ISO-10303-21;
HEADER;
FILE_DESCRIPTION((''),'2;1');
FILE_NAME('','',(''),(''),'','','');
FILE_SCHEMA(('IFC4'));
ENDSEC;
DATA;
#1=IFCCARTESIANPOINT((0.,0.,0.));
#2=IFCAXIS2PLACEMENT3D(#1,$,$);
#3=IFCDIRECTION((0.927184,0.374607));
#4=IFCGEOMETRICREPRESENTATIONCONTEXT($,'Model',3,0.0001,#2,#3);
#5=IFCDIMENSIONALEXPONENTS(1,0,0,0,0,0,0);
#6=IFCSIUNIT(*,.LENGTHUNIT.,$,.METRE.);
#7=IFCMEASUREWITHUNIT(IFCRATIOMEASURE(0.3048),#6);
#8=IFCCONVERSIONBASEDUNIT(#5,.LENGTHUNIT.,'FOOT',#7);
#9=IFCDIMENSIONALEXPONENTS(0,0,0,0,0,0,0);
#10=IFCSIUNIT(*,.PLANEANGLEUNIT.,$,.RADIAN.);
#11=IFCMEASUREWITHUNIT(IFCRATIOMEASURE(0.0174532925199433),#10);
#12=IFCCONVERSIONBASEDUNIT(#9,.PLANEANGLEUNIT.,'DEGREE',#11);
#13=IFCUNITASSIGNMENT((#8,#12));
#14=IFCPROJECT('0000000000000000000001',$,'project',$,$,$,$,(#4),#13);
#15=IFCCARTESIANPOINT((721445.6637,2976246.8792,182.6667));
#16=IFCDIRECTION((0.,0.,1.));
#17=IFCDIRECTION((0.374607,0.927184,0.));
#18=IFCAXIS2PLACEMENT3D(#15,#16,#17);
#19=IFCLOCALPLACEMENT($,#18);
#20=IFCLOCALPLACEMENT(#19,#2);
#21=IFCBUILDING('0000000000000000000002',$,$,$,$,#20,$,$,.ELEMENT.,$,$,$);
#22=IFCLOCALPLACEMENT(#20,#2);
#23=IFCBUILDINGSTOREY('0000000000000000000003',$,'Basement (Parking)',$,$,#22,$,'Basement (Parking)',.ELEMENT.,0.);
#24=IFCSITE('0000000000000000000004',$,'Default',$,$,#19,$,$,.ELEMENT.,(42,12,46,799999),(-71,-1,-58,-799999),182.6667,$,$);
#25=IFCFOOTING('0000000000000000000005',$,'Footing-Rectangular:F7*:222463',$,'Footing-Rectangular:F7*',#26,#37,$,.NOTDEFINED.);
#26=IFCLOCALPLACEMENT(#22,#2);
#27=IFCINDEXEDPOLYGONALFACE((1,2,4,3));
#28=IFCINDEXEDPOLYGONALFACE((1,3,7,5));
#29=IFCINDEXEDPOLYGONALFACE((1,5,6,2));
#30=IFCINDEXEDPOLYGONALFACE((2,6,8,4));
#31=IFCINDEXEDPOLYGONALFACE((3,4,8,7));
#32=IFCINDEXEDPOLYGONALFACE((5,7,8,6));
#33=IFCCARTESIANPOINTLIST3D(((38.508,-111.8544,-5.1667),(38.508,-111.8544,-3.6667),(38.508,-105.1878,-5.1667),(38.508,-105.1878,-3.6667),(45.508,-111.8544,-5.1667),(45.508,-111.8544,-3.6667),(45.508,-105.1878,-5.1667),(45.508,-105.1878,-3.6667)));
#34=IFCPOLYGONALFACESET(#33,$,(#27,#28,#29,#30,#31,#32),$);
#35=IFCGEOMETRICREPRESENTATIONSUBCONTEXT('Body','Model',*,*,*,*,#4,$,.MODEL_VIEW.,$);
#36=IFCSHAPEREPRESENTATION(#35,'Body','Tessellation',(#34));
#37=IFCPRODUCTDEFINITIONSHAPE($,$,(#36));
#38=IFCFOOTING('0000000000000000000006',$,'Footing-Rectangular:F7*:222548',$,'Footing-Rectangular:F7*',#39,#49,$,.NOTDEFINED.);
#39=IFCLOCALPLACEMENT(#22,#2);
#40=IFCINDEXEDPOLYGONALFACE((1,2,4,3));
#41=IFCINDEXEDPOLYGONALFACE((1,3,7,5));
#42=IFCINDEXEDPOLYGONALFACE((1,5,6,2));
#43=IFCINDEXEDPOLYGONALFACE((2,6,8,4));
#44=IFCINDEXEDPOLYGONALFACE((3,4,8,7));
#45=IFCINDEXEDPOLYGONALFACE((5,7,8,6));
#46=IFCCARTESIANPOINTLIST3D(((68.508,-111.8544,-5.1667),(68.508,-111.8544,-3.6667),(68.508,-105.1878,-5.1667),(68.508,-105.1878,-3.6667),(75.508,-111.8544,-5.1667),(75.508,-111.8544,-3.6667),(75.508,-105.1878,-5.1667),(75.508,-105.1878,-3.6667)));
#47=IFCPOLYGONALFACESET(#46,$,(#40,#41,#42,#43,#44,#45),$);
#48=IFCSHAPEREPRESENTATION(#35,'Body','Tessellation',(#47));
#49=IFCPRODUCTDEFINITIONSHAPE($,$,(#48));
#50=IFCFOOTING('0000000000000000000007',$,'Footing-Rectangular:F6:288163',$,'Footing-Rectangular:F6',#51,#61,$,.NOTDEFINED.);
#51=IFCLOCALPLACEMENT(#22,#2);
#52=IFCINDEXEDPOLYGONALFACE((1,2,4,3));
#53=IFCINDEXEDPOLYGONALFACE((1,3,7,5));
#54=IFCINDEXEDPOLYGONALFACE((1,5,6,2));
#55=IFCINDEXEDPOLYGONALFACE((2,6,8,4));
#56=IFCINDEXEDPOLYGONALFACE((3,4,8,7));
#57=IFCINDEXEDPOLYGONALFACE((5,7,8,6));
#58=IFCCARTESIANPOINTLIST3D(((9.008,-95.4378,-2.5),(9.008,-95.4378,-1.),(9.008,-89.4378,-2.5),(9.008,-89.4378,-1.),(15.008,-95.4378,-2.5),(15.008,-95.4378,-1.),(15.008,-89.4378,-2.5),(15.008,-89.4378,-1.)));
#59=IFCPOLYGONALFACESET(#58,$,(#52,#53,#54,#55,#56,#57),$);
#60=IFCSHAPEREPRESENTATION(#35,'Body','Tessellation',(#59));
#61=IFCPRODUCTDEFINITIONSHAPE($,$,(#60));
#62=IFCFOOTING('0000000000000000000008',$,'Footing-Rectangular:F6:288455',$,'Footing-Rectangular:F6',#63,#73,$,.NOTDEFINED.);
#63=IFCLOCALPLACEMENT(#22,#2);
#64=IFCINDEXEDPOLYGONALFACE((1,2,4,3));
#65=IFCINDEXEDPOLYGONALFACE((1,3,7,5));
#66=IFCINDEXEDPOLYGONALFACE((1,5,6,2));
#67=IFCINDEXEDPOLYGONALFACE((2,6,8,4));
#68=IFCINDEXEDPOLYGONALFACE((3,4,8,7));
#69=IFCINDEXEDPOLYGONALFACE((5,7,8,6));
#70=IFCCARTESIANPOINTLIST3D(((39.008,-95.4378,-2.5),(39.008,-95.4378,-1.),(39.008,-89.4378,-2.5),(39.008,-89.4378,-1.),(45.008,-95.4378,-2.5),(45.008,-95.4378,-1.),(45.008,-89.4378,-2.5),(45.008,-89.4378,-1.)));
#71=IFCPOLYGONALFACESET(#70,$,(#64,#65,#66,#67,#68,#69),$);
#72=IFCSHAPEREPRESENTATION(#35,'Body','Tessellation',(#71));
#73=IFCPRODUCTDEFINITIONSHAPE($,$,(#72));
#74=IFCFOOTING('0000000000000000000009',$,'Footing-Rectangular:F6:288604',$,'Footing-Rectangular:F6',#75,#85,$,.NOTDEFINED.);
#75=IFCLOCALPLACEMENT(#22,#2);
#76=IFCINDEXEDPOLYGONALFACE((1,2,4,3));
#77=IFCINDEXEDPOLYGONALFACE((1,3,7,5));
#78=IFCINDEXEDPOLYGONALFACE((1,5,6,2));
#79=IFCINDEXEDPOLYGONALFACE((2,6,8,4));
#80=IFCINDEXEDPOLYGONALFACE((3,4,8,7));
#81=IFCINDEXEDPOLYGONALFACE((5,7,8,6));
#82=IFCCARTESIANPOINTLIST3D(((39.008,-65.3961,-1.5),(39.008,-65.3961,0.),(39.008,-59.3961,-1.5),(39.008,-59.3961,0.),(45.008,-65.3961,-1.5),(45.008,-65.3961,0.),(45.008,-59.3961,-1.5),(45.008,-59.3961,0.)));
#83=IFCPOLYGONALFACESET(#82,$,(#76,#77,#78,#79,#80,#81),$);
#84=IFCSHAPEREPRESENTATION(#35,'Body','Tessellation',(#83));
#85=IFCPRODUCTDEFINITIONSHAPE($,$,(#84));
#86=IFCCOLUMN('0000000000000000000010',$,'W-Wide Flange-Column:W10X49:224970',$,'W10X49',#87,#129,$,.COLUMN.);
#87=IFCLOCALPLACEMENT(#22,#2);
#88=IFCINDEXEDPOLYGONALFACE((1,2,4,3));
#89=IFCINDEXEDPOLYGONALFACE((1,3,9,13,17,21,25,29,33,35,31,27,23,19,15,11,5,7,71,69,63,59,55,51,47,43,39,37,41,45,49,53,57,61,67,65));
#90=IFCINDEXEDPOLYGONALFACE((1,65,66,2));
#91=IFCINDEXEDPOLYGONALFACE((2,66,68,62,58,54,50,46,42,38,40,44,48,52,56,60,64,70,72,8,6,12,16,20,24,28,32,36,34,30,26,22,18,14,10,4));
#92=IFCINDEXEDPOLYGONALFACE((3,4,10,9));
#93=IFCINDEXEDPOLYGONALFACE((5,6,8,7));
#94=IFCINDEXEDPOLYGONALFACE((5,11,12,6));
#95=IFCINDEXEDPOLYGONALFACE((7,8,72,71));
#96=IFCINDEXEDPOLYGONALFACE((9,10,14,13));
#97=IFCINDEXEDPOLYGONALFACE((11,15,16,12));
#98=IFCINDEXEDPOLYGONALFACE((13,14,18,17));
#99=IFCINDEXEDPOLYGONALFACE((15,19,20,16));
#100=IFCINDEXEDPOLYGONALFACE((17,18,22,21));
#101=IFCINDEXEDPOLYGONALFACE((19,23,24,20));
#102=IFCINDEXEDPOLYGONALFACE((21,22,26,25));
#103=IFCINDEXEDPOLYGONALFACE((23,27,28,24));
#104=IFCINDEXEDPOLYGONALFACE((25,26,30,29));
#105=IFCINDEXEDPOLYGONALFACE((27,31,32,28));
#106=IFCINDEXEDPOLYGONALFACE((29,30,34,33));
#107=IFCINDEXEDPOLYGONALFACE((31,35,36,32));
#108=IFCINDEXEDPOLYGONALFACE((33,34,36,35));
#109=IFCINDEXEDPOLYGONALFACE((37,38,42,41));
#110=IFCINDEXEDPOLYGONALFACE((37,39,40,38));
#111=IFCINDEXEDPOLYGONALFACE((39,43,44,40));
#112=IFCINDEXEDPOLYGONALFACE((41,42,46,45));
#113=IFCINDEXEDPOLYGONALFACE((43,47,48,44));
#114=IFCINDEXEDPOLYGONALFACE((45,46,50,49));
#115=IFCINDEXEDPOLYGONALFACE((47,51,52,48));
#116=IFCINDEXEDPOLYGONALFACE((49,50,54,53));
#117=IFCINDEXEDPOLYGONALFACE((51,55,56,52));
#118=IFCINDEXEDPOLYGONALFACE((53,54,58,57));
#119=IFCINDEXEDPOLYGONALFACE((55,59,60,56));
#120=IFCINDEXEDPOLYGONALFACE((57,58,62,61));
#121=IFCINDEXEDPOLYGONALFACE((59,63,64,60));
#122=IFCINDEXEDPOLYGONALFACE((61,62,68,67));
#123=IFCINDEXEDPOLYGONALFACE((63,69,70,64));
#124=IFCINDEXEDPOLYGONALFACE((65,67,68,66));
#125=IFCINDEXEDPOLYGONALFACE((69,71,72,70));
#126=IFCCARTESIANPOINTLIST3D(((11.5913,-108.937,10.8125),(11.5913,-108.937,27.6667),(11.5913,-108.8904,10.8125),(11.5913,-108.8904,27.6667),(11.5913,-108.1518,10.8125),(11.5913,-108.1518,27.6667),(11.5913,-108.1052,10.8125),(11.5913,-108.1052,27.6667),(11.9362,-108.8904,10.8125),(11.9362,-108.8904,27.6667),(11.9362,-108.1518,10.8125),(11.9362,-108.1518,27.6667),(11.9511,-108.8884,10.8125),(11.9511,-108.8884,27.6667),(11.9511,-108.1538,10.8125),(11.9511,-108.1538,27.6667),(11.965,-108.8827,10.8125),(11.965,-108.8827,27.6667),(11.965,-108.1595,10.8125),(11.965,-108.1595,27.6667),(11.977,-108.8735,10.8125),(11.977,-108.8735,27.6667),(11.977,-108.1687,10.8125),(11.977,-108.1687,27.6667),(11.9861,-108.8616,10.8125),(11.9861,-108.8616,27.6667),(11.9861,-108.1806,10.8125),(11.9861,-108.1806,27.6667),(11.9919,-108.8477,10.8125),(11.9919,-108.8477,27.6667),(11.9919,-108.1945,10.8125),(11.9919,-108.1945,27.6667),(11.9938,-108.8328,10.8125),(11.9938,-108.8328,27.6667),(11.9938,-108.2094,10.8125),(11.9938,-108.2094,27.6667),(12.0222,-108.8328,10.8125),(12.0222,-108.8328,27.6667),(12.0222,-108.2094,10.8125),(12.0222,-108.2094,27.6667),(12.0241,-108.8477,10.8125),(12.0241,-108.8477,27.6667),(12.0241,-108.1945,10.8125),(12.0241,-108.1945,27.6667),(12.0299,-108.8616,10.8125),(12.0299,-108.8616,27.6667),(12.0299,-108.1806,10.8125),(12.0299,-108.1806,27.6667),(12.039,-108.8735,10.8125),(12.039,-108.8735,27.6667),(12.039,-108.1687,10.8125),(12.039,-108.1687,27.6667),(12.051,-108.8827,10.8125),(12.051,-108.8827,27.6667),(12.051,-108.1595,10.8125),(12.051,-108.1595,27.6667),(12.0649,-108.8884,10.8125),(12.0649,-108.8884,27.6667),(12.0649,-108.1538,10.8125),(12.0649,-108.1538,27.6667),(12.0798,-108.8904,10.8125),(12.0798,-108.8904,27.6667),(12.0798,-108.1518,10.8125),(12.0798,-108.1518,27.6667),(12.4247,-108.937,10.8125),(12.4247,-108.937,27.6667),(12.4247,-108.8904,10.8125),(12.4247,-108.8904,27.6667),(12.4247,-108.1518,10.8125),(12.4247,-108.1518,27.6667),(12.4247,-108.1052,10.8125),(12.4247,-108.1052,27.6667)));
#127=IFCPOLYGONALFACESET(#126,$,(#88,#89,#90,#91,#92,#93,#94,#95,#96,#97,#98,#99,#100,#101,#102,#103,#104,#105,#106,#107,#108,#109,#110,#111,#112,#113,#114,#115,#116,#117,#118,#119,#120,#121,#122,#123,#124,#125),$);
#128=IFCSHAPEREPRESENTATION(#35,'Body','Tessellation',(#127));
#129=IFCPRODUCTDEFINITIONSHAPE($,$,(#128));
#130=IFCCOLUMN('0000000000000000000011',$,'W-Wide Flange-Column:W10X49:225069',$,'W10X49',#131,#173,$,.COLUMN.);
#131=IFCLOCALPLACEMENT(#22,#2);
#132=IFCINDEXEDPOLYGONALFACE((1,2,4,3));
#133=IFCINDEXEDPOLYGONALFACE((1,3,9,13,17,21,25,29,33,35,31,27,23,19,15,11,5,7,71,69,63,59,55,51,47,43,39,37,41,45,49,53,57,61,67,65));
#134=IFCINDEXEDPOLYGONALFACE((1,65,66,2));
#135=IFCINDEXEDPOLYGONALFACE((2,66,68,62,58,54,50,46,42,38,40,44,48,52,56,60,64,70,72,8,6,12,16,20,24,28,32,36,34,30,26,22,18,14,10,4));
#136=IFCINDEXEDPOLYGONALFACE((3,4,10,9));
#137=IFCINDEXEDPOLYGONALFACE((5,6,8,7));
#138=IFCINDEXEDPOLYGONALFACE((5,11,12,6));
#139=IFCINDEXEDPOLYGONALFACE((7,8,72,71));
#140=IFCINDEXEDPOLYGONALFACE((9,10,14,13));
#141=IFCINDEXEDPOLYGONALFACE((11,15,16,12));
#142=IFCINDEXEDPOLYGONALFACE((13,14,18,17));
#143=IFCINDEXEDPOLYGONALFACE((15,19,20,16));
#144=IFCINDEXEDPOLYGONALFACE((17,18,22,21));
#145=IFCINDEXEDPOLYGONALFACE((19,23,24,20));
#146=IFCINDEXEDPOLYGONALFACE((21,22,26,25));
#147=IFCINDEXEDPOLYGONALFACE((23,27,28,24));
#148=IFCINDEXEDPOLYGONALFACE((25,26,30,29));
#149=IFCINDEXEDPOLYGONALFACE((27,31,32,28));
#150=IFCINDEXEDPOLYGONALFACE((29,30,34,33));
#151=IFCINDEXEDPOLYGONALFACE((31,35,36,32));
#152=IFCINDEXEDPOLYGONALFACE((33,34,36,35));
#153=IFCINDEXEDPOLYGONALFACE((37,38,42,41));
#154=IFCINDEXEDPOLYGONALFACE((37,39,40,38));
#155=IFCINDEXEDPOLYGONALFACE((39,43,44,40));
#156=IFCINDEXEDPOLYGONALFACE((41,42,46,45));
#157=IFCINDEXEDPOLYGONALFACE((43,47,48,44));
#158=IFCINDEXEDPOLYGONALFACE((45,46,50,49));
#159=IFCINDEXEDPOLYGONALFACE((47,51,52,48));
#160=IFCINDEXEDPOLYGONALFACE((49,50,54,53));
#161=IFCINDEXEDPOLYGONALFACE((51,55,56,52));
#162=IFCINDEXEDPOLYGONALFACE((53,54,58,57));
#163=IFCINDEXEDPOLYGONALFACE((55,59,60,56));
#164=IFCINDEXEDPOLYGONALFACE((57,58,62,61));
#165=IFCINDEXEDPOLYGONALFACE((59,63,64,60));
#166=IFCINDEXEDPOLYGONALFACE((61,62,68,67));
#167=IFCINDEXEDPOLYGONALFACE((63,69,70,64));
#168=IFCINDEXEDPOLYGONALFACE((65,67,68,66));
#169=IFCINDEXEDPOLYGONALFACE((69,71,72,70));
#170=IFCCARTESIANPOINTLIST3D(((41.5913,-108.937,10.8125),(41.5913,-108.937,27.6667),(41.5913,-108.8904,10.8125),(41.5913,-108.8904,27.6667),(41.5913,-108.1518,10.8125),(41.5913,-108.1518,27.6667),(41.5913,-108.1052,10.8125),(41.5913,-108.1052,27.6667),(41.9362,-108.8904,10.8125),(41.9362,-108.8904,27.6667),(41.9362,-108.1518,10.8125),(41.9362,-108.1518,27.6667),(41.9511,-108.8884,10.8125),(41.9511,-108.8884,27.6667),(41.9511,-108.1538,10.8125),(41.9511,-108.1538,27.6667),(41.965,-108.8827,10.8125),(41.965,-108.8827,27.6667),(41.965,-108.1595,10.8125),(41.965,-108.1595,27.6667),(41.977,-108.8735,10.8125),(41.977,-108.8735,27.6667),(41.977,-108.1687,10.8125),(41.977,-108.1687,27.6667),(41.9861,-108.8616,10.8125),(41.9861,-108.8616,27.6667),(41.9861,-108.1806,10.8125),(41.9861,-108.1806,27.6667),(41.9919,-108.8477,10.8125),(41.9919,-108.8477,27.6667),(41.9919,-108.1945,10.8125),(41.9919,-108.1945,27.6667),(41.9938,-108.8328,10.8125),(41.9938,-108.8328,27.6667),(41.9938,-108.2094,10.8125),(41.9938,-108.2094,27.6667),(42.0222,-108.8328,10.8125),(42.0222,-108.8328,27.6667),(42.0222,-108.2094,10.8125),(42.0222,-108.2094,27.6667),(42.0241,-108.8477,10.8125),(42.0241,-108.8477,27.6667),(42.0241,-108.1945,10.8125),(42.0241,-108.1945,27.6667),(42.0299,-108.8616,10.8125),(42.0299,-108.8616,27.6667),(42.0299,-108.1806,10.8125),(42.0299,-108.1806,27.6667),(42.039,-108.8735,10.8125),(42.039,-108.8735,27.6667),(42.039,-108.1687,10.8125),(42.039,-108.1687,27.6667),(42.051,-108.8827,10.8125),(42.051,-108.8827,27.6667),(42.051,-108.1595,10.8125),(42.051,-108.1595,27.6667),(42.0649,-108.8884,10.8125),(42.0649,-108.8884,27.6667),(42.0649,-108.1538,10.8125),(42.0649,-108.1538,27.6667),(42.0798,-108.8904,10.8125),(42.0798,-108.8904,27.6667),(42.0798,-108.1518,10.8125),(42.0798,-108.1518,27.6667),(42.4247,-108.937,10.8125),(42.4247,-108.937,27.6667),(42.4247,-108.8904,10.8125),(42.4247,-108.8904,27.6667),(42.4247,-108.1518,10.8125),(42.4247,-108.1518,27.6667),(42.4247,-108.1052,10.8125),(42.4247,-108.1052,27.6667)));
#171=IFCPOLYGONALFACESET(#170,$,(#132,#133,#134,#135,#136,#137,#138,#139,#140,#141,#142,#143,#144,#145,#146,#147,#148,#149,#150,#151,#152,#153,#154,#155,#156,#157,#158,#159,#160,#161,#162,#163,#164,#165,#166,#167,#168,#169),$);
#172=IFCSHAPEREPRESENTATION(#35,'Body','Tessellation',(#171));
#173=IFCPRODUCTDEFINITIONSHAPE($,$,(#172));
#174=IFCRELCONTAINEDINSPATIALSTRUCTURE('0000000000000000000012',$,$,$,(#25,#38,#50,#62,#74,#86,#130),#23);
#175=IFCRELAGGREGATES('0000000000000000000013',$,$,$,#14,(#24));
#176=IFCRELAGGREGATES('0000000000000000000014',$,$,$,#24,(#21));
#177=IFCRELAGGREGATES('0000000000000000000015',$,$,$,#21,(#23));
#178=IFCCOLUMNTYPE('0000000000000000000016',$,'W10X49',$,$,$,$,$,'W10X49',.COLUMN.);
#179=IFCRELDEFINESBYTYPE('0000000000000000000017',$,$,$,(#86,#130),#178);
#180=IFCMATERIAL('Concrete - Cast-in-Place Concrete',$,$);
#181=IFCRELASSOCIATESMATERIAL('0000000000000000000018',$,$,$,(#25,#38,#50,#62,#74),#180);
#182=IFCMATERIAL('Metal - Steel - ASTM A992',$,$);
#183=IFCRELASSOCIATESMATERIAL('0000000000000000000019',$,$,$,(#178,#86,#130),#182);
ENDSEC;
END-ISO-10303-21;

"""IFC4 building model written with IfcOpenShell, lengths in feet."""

from ifc_helpers import new_model, entity, si_unit, converted_unit, direction, frame, frame_2d, origin, origin_2d_with_axis, place, context, subcontext, project, spatial, rectangle, i_section, extrude, source, transform, mapped, material, type_object, type_shapes, element, save


model = new_model("IFC4")

# Units and contexts
model_context = context("Model", 3, precision=0.0001, world=origin(), true_north=direction((0.927184, 0.374607)))
body_context = subcontext(model_context, "Body", "Model", "MODEL_VIEW")
ifc_project = project(units=[converted_unit("LENGTHUNIT", "FOOT", entity("IfcRatioMeasure", 0.3048), si_unit("LENGTHUNIT", "METRE"), dimensions=[1, 0, 0, 0, 0, 0, 0]), converted_unit("PLANEANGLEUNIT", "DEGREE", entity("IfcRatioMeasure", 0.0174532925199433), si_unit("PLANEANGLEUNIT", "RADIAN"), dimensions=[0, 0, 0, 0, 0, 0, 0])], contexts=[model_context])

# Site, building, storey
site_placement = place(None, frame((721445.6637, 2976246.8792, 182.6667), z_axis=(0.0, 0.0, 1.0), x_axis=(0.374607, 0.927184, 0.0)))
site = spatial("IfcSite", under=ifc_project, at=site_placement, Name="Default", CompositionType="ELEMENT", RefLatitude=(42, 12, 46, 799999), RefLongitude=(-71, -1, -58, -799999), RefElevation=182.6667)
building_placement = place(site_placement, origin())
building = spatial("IfcBuilding", under=site, at=building_placement, CompositionType="ELEMENT")
storey_placement = place(building_placement, origin())
storey = spatial("IfcBuildingStorey", under=building, at=storey_placement, Name="Basement (Parking)", LongName="Basement (Parking)", CompositionType="ELEMENT", Elevation=0.0)

# Footings
ifc_material_1 = material(Name="Concrete - Cast-in-Place Concrete")
footing_1_placement = place(storey_placement, frame((38.508, -111.8544, -5.1667)))
element("IfcFooting", 1, at=footing_1_placement, inside=storey, material=ifc_material_1, Name="Footing-Rectangular:F7*:222463", ObjectType="Footing-Rectangular:F7*", PredefinedType="NOTDEFINED", context=body_context, shape_type="SweptSolid", body=[
    extrude(rectangle(XDim=6.6667, YDim=7.0, at=frame_2d((0.5, 0.0), x_axis=(1.0, 0.0))), frame((3.5, 3.8333, 0.0), z_axis=(0.0, 0.0, 1.0), x_axis=(0.0, -1.0, 0.0)), (0.0, 0.0, 1.0), 1.5),
])
footing_2_placement = place(storey_placement, frame((68.508, -111.8544, -5.1667)))
element("IfcFooting", 2, at=footing_2_placement, inside=storey, material=ifc_material_1, Name="Footing-Rectangular:F7*:222548", ObjectType="Footing-Rectangular:F7*", PredefinedType="NOTDEFINED", context=body_context, shape_type="SweptSolid", body=[
    extrude(rectangle(XDim=6.6667, YDim=7.0, at=frame_2d((0.5, 0.0), x_axis=(1.0, 0.0))), frame((3.5, 3.8333, 0.0), z_axis=(0.0, 0.0, 1.0), x_axis=(0.0, -1.0, 0.0)), (0.0, 0.0, 1.0), 1.5),
])
for number, where, name in (
    (3, (9.008, -95.4378, -2.5), "Footing-Rectangular:F6:288163"),
    (4, (39.008, -95.4378, -2.5), "Footing-Rectangular:F6:288455"),
    (5, (39.008, -65.3961, -1.5), "Footing-Rectangular:F6:288604"),
):
    element("IfcFooting", number, at=place(storey_placement, frame(where)), inside=storey, material=ifc_material_1, Name=name, ObjectType="Footing-Rectangular:F6", PredefinedType="NOTDEFINED", context=body_context, shape_type="SweptSolid", body=[
        extrude(rectangle(XDim=6.0, YDim=6.0, at=origin_2d_with_axis()), frame((3.0, 3.0, 0.0), z_axis=(0.0, 0.0, 1.0), x_axis=(-1.0, 0.0, 0.0)), (0.0, 0.0, 1.0), 1.5),
    ])

# Columns
ifc_material_2 = material(Name="Metal - Steel - ASTM A992")
column_type_1 = type_object("IfcColumnType", Name="W10X49", ElementType="W10X49", PredefinedType="COLUMN", material=ifc_material_2)
shared_shape_1 = source(origin(), body_context, "Body", "SweptSolid", [
    extrude(i_section(OverallWidth=0.8333, OverallDepth=0.8317, WebThickness=0.0283, FlangeThickness=0.0465, FilletRadius=0.0576, at=frame_2d((0.0, 0.0), x_axis=(0.0, 1.0))), frame((0.0, 0.0, 10.8125), z_axis=(0.0, 0.0, 1.0), x_axis=(0.0, -1.0, 0.0)), (0.0, 0.0, 1.0), 16.8542),
])
type_shapes(column_type_1, [shared_shape_1])
for number, where, name in (
    (6, (12.008, -108.5211, 0.0), "W-Wide Flange-Column:W10X49:224970"),
    (7, (42.008, -108.5211, 0.0), "W-Wide Flange-Column:W10X49:225069"),
):
    element("IfcColumn", number, at=place(storey_placement, frame(where)), inside=storey, type_object=column_type_1, material=ifc_material_2, Name=name, ObjectType="W10X49", PredefinedType="COLUMN", context=body_context, shape_type="MappedRepresentation", body=[
        mapped(shared_shape_1, transform((0.0, 0.0, 0.0), scale=1.0)),
    ])

save(model, "model.ifc")
